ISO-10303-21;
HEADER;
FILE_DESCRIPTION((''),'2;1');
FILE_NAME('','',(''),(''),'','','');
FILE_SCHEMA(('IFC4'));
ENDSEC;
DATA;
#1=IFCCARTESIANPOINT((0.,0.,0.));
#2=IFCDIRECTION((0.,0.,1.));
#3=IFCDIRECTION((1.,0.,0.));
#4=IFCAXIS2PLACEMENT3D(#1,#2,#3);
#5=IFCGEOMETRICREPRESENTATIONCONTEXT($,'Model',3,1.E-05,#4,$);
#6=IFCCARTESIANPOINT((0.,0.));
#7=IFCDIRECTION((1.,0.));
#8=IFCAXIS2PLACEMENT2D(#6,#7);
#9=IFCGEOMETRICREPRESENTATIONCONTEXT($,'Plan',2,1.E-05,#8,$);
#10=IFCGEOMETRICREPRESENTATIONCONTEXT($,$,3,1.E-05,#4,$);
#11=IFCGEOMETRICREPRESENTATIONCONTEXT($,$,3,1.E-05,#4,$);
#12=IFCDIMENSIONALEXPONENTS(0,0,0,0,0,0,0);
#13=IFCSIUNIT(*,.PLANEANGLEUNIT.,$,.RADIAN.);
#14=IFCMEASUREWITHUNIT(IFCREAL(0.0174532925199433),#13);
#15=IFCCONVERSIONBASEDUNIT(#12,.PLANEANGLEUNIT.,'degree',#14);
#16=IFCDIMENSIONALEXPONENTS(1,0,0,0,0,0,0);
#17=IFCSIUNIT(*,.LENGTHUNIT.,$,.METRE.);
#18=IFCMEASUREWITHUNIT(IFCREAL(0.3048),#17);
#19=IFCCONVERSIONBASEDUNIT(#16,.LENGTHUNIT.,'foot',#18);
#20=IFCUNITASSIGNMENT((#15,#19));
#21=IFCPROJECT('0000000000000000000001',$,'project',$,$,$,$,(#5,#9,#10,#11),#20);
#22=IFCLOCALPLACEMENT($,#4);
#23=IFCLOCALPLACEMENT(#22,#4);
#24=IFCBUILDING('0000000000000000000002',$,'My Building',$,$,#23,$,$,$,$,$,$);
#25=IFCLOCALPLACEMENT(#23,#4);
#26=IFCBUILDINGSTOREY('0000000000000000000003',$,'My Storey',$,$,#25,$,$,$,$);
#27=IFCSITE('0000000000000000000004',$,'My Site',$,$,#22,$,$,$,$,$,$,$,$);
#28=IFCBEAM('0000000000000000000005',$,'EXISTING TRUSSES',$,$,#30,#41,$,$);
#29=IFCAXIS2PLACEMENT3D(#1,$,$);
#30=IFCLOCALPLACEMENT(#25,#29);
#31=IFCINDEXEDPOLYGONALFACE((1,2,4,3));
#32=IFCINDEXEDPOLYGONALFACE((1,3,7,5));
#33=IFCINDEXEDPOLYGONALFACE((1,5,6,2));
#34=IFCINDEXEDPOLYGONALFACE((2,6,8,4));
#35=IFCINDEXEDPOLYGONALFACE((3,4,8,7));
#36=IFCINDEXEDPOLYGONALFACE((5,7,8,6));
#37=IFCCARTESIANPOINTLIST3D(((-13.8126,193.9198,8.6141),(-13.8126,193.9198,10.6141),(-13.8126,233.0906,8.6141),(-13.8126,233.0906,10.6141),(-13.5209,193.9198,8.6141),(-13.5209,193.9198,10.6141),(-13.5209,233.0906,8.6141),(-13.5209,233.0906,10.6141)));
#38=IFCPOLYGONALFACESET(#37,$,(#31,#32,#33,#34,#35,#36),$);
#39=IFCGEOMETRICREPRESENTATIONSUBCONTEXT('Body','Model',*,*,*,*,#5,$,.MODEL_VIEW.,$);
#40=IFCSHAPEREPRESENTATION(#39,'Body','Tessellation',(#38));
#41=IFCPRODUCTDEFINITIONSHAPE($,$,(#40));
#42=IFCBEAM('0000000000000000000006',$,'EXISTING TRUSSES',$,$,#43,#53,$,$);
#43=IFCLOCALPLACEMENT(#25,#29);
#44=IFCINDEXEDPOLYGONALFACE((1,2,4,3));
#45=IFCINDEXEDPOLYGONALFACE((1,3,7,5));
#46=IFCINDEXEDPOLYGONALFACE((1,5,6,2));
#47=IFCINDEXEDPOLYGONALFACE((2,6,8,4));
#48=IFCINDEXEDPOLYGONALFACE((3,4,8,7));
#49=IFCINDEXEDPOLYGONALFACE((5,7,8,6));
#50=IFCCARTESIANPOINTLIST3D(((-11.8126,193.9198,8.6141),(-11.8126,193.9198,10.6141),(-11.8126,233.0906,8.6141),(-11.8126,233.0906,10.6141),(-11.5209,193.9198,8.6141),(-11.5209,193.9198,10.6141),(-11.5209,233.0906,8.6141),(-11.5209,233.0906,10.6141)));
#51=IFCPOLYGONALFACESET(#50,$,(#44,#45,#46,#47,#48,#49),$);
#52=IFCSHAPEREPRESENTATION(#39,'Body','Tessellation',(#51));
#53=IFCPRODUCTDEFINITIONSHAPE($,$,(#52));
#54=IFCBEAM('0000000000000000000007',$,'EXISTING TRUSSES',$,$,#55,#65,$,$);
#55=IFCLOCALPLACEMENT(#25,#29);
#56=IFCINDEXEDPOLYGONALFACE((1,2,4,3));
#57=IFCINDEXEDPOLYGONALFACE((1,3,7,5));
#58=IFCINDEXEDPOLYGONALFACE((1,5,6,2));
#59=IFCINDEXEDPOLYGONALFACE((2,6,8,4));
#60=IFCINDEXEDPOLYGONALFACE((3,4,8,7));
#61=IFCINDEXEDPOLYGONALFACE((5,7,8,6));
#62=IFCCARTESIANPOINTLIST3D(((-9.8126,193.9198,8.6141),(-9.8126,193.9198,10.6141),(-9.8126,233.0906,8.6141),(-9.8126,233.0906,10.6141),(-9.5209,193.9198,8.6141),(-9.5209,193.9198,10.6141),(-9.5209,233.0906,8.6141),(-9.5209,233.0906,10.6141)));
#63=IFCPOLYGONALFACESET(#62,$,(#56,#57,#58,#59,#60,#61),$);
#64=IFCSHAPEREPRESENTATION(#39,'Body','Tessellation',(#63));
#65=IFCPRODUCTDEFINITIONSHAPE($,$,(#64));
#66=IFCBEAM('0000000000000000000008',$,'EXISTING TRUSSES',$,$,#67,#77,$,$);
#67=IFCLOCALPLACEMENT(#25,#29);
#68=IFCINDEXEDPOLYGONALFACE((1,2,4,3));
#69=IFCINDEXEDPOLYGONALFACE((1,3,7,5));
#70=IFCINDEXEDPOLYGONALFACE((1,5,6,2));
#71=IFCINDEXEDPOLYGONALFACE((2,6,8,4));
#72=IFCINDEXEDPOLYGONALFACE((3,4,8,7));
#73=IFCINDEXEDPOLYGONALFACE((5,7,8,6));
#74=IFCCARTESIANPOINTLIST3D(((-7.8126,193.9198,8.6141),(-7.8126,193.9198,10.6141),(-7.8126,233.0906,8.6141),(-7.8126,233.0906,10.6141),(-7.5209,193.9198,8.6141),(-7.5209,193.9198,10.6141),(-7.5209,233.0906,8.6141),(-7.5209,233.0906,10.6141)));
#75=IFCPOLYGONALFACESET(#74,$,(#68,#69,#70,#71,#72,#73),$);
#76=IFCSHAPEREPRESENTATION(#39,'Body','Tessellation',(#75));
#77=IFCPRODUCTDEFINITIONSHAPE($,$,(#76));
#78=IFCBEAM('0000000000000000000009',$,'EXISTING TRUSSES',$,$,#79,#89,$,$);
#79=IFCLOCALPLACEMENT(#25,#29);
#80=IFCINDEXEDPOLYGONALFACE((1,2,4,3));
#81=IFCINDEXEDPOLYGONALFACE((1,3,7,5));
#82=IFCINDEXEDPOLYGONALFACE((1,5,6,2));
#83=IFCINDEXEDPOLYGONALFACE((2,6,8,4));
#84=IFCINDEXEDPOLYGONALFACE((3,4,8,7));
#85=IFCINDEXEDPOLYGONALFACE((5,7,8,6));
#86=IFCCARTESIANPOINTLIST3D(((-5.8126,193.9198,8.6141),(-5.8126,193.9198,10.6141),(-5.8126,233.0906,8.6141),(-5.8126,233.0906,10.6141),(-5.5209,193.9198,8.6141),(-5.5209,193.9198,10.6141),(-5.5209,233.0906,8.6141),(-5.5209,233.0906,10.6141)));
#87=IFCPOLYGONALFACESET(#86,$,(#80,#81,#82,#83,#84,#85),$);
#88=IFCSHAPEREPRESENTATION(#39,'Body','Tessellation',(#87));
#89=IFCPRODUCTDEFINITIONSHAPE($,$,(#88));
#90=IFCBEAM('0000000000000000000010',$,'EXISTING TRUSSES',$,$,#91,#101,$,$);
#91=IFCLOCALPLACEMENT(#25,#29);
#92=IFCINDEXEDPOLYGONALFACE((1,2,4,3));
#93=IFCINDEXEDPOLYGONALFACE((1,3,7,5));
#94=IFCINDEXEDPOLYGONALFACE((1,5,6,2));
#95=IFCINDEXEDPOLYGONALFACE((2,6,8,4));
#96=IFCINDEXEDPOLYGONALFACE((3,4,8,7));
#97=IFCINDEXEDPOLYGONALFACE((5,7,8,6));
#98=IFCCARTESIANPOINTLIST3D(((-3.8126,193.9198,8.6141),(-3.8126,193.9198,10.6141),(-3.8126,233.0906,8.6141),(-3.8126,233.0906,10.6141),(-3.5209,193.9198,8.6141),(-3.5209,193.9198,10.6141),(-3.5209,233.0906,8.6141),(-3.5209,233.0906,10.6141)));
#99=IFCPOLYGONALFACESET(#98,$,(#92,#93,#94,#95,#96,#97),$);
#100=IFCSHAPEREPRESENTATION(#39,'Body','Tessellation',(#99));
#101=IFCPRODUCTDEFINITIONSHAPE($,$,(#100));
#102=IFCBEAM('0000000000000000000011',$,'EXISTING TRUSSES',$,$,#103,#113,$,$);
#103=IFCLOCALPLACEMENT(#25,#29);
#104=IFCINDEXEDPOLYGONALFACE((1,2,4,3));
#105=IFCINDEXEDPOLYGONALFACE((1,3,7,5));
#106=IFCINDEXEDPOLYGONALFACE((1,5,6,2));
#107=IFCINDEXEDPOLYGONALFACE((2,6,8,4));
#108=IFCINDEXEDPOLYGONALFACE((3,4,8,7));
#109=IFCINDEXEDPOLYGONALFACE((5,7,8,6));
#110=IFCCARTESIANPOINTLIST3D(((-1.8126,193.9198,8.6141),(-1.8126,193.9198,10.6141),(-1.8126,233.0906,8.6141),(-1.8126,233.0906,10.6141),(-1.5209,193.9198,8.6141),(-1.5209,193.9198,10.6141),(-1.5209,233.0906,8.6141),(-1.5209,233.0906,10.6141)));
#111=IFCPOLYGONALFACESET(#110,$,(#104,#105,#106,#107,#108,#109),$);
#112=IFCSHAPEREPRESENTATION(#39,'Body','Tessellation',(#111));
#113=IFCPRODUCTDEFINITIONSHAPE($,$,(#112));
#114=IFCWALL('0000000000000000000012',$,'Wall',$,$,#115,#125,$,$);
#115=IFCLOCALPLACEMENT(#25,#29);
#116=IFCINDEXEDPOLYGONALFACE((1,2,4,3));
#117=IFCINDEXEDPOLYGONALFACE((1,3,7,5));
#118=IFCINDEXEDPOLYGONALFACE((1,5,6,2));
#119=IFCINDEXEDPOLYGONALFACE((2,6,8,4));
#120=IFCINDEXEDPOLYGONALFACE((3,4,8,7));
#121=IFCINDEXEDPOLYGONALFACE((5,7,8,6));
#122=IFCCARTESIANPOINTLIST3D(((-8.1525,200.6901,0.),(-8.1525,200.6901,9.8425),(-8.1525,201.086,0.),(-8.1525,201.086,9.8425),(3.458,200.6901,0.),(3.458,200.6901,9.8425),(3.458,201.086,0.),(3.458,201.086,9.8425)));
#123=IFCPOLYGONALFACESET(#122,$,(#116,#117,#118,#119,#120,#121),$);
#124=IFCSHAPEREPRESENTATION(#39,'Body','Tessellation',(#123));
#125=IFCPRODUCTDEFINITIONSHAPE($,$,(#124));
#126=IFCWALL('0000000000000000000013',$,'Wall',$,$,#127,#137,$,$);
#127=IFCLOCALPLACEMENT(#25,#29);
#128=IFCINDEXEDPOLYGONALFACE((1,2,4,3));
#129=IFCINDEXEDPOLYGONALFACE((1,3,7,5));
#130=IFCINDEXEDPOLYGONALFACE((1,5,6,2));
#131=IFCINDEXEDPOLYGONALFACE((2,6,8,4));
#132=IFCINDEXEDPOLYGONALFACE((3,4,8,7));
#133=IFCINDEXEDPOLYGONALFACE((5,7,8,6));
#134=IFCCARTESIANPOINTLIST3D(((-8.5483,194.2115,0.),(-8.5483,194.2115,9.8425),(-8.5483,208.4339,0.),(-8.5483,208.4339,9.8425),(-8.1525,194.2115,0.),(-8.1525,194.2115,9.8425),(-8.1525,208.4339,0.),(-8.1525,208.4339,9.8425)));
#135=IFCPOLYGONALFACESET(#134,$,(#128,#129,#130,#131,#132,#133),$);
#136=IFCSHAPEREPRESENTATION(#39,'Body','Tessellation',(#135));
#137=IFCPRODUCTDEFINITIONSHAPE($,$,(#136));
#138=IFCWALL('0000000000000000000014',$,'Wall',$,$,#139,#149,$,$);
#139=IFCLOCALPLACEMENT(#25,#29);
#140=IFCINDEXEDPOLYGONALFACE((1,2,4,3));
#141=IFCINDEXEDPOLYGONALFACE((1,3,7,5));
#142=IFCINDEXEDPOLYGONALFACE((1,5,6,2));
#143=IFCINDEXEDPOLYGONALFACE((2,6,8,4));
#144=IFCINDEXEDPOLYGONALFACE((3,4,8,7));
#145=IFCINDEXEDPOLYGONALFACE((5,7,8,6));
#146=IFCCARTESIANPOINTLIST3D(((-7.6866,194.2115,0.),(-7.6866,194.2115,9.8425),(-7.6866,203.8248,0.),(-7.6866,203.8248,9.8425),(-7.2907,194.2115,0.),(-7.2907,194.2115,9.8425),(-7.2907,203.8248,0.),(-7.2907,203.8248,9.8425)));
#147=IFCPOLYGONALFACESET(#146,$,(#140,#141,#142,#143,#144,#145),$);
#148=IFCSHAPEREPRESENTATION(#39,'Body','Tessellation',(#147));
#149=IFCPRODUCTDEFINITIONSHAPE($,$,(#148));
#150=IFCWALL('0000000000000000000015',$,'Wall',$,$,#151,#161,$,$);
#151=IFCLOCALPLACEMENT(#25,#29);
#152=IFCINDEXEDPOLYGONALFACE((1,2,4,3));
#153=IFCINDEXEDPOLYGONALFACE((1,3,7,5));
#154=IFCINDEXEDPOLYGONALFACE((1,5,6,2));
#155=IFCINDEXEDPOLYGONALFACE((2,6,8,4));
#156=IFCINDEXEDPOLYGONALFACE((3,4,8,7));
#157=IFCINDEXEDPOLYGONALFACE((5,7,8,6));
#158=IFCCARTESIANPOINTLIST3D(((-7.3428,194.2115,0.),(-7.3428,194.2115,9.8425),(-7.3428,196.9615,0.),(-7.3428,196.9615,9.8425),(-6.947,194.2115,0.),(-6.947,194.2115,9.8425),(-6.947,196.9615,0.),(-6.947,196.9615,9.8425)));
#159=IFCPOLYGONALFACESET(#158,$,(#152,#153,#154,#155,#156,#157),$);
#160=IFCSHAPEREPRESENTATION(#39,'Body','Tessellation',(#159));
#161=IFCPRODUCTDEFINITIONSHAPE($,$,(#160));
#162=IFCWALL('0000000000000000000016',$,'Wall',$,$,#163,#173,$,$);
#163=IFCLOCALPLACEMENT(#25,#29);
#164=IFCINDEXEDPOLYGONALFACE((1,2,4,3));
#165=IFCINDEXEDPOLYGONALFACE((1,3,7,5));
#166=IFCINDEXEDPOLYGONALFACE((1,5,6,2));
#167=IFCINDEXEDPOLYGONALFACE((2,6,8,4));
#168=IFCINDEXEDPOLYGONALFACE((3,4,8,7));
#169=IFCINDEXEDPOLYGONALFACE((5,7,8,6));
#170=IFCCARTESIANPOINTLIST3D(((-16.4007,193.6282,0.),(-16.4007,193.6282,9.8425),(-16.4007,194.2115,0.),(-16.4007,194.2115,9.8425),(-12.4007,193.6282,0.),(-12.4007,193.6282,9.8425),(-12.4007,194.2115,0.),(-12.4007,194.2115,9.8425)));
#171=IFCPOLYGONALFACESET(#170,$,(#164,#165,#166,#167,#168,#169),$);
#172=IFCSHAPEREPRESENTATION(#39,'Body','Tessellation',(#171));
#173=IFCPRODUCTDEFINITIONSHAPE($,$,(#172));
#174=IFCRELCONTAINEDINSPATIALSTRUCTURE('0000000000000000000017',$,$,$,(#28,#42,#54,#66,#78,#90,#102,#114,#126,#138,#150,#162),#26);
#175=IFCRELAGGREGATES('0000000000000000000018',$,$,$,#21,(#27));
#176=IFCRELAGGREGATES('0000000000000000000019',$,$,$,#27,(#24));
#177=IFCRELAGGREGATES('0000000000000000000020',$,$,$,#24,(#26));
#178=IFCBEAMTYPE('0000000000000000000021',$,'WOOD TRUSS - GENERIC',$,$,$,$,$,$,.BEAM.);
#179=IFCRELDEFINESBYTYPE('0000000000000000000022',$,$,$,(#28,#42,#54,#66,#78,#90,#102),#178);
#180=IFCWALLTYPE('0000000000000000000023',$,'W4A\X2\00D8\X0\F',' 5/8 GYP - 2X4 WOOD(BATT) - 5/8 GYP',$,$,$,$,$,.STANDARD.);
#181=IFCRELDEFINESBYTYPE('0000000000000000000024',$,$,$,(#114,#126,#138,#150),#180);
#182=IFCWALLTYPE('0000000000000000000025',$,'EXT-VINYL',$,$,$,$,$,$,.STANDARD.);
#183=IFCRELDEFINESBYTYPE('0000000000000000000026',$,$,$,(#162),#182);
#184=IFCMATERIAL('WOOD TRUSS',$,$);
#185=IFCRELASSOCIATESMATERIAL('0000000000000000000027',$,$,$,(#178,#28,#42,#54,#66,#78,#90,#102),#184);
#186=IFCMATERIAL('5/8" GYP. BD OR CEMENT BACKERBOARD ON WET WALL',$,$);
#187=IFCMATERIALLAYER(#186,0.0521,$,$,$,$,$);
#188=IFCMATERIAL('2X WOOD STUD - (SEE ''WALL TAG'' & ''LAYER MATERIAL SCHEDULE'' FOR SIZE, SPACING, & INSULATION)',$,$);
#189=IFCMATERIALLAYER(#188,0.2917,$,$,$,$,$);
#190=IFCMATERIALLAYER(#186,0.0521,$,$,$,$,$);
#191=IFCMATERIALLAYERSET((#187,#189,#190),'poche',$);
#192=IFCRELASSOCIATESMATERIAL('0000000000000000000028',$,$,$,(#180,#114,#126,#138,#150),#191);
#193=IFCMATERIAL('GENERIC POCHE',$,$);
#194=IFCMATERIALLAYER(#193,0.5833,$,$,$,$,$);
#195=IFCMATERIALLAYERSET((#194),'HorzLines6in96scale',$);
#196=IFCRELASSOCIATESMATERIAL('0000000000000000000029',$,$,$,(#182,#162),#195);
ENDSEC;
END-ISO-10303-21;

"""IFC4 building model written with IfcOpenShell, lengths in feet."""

from ifc_helpers import new_model, entity, si_unit, converted_unit, frame, origin_with_axes, origin_2d_with_axis, place, context, subcontext, project, spatial, indexed_curve, rectangle, outline, extrude, material, layer, layer_set, layer_usage, material_profile, profile_set, profile_usage, type_object, element, save


model = new_model("IFC4")

# Units and contexts
model_context = context("Model", 3, precision=1e-05, world=origin_with_axes())
plan_context = context("Plan", 2, precision=1e-05, world=origin_2d_with_axis())
context_of_model_1 = context(None, 3, precision=1e-05, world=origin_with_axes())
context_of_model_2 = context(None, 3, precision=1e-05, world=origin_with_axes())
body_context_1 = subcontext(model_context, "Body", "Model", "MODEL_VIEW")
ifc_project = project(units=[converted_unit("PLANEANGLEUNIT", "degree", entity("IfcReal", 0.0174532925199433), si_unit("PLANEANGLEUNIT", "RADIAN"), dimensions=[0, 0, 0, 0, 0, 0, 0]), converted_unit("LENGTHUNIT", "foot", entity("IfcReal", 0.3048), si_unit("LENGTHUNIT", "METRE"), dimensions=[1, 0, 0, 0, 0, 0, 0])], contexts=[model_context, plan_context, context_of_model_1, context_of_model_2])

# Site, building, storey
site_placement = place(None, origin_with_axes())
site = spatial("IfcSite", under=ifc_project, at=site_placement, Name="My Site")
building_placement = place(site_placement, origin_with_axes())
building = spatial("IfcBuilding", under=site, at=building_placement, Name="My Building")
storey_placement = place(building_placement, origin_with_axes())
storey = spatial("IfcBuildingStorey", under=building, at=storey_placement, Name="My Storey")

# Beams
ifc_material_1 = material(Name="WOOD TRUSS")
ifc_material_profile = material_profile(ifc_material_1, rectangle(XDim=0.2917, YDim=2.0))
ifc_profile_set = profile_set([ifc_material_profile])
ifc_profile_usage_1 = profile_usage(ifc_profile_set, cardinal=5)
beam_type = type_object("IfcBeamType", Name="WOOD TRUSS - GENERIC", PredefinedType="BEAM", material=ifc_profile_set)
beam_1_placement = place(storey_placement, frame((-13.6667, 193.9198, 9.6141), z_axis=(0.0, 1.0, 0.0), x_axis=(-1.0, 0.0, 0.0)))
element("IfcBeam", 1, at=beam_1_placement, inside=storey, type_object=beam_type, material=ifc_profile_usage_1, Name="EXISTING TRUSSES", context=body_context_1, shape_type="SweptSolid", body=[
    extrude(rectangle(XDim=0.2917, YDim=2.0), origin_with_axes(), (0.0, 0.0, 1.0), 39.1707),
])
ifc_profile_usage_2 = profile_usage(ifc_profile_set, cardinal=5)
beam_2_placement = place(storey_placement, frame((-11.6667, 193.9198, 9.6141), z_axis=(0.0, 1.0, 0.0), x_axis=(-1.0, 0.0, 0.0)))
element("IfcBeam", 2, at=beam_2_placement, inside=storey, type_object=beam_type, material=ifc_profile_usage_2, Name="EXISTING TRUSSES", context=body_context_1, shape_type="SweptSolid", body=[
    extrude(rectangle(XDim=0.2917, YDim=2.0), origin_with_axes(), (0.0, 0.0, 1.0), 39.1707),
])
ifc_profile_usage_3 = profile_usage(ifc_profile_set, cardinal=5)
beam_3_placement = place(storey_placement, frame((-9.6667, 193.9198, 9.6141), z_axis=(0.0, 1.0, 0.0), x_axis=(-1.0, 0.0, 0.0)))
element("IfcBeam", 3, at=beam_3_placement, inside=storey, type_object=beam_type, material=ifc_profile_usage_3, Name="EXISTING TRUSSES", context=body_context_1, shape_type="SweptSolid", body=[
    extrude(rectangle(XDim=0.2917, YDim=2.0), origin_with_axes(), (0.0, 0.0, 1.0), 39.1707),
])
ifc_profile_usage_4 = profile_usage(ifc_profile_set, cardinal=5)
beam_4_placement = place(storey_placement, frame((-7.6667, 193.9198, 9.6141), z_axis=(0.0, 1.0, 0.0), x_axis=(-1.0, 0.0, 0.0)))
element("IfcBeam", 4, at=beam_4_placement, inside=storey, type_object=beam_type, material=ifc_profile_usage_4, Name="EXISTING TRUSSES", context=body_context_1, shape_type="SweptSolid", body=[
    extrude(rectangle(XDim=0.2917, YDim=2.0), origin_with_axes(), (0.0, 0.0, 1.0), 39.1707),
])
ifc_profile_usage_5 = profile_usage(ifc_profile_set, cardinal=5)
beam_5_placement = place(storey_placement, frame((-5.6667, 193.9198, 9.6141), z_axis=(0.0, 1.0, 0.0), x_axis=(-1.0, 0.0, 0.0)))
element("IfcBeam", 5, at=beam_5_placement, inside=storey, type_object=beam_type, material=ifc_profile_usage_5, Name="EXISTING TRUSSES", context=body_context_1, shape_type="SweptSolid", body=[
    extrude(rectangle(XDim=0.2917, YDim=2.0), origin_with_axes(), (0.0, 0.0, 1.0), 39.1707),
])
ifc_profile_usage_6 = profile_usage(ifc_profile_set, cardinal=5)
beam_6_placement = place(storey_placement, frame((-3.6667, 193.9198, 9.6141), z_axis=(0.0, 1.0, 0.0), x_axis=(-1.0, 0.0, 0.0)))
element("IfcBeam", 6, at=beam_6_placement, inside=storey, type_object=beam_type, material=ifc_profile_usage_6, Name="EXISTING TRUSSES", context=body_context_1, shape_type="SweptSolid", body=[
    extrude(rectangle(XDim=0.2917, YDim=2.0), origin_with_axes(), (0.0, 0.0, 1.0), 39.1707),
])
ifc_profile_usage_7 = profile_usage(ifc_profile_set, cardinal=5)
beam_7_placement = place(storey_placement, frame((-1.6667, 193.9198, 9.6141), z_axis=(0.0, 1.0, 0.0), x_axis=(-1.0, 0.0, 0.0)))
element("IfcBeam", 7, at=beam_7_placement, inside=storey, type_object=beam_type, material=ifc_profile_usage_7, Name="EXISTING TRUSSES", context=body_context_1, shape_type="SweptSolid", body=[
    extrude(rectangle(XDim=0.2917, YDim=2.0), origin_with_axes(), (0.0, 0.0, 1.0), 39.1707),
])

# Walls
ifc_material_2 = material(Name="5/8\" GYP. BD OR CEMENT BACKERBOARD ON WET WALL")
ifc_layer_1 = layer(ifc_material_2, 0.0521)
ifc_material_3 = material(Name="2X WOOD STUD - (SEE 'WALL TAG' & 'LAYER MATERIAL SCHEDULE' FOR SIZE, SPACING, & INSULATION)")
ifc_layer_2 = layer(ifc_material_3, 0.2917)
ifc_layer_3 = layer(ifc_material_2, 0.0521)
ifc_layer_set_1 = layer_set([ifc_layer_1, ifc_layer_2, ifc_layer_3], Name="poche")
ifc_layer_usage_1 = layer_usage(ifc_layer_set_1, "AXIS2", "POSITIVE", 0.0)
wall_type_1 = type_object("IfcWallType", Name="W4AØF", Description=" 5/8 GYP - 2X4 WOOD(BATT) - 5/8 GYP", PredefinedType="STANDARD", material=ifc_layer_set_1)
wall_1_placement = place(storey_placement, frame((-8.1525, 200.6901, 0.0), z_axis=(0.0, 0.0, 1.0), x_axis=(1.0, 0.0, 0.0)))
element("IfcWall", 8, at=wall_1_placement, inside=storey, type_object=wall_type_1, material=ifc_layer_usage_1, Name="Wall", context=body_context_1, shape_type="SweptSolid", body=[
    extrude(outline(indexed_curve([(0.0, 0.0), (0.0, 0.3958), (11.6105, 0.3958), (11.6105, 0.0), (0.0, 0.0)], self_intersect=False)), origin_with_axes(), (0.0, 0.0, 1.0), 9.8425),
])
ifc_layer_usage_2 = layer_usage(ifc_layer_set_1, "AXIS2", "POSITIVE", 0.0)
wall_2_placement = place(storey_placement, frame((-8.1525, 194.2115, 0.0), z_axis=(0.0, 0.0, 1.0), x_axis=(0.000001, 1.0, 0.0)))
element("IfcWall", 9, at=wall_2_placement, inside=storey, type_object=wall_type_1, material=ifc_layer_usage_2, Name="Wall", context=body_context_1, shape_type="SweptSolid", body=[
    extrude(outline(indexed_curve([(0.0, 0.0), (0.0, 0.3958), (14.2224, 0.3958), (14.2224, 0.0), (0.0, 0.0)], self_intersect=False)), origin_with_axes(), (0.0, 0.0, 1.0), 9.8425),
])

# Wall
ifc_layer_usage_3 = layer_usage(ifc_layer_set_1, "AXIS2", "POSITIVE", 0.0)
wall_3_placement = place(storey_placement, frame((-7.2907, 194.2115, 0.0), z_axis=(0.0, 0.0, 1.0), x_axis=(0.0, 1.0, 0.0)))
element("IfcWall", 10, at=wall_3_placement, inside=storey, type_object=wall_type_1, material=ifc_layer_usage_3, Name="Wall", context=body_context_1, shape_type="SweptSolid", body=[
    extrude(outline(indexed_curve([(0.0, 0.0), (0.0, 0.3958), (9.6133, 0.3958), (9.6133, 0.0), (0.0, 0.0)], self_intersect=False)), origin_with_axes(), (0.0, 0.0, 1.0), 9.8425),
])

# Walls
ifc_layer_usage_4 = layer_usage(ifc_layer_set_1, "AXIS2", "POSITIVE", 0.0)
wall_4_placement = place(storey_placement, frame((-6.947, 194.2115, 0.0), z_axis=(0.0, 0.0, 1.0), x_axis=(0.0, 1.0, 0.0)))
element("IfcWall", 11, at=wall_4_placement, inside=storey, type_object=wall_type_1, material=ifc_layer_usage_4, Name="Wall", context=body_context_1, shape_type="SweptSolid", body=[
    extrude(outline(indexed_curve([(0.0, 0.0), (0.0, 0.3958), (2.75, 0.3958), (2.75, 0.0), (0.0, 0.0)], self_intersect=False)), origin_with_axes(), (0.0, 0.0, 1.0), 9.8425),
])
ifc_material_4 = material(Name="GENERIC POCHE")
ifc_layer_4 = layer(ifc_material_4, 0.5833)
ifc_layer_set_2 = layer_set([ifc_layer_4], Name="HorzLines6in96scale")
ifc_layer_usage_5 = layer_usage(ifc_layer_set_2, "AXIS2", "POSITIVE", 0.0)
wall_type_2 = type_object("IfcWallType", Name="EXT-VINYL", PredefinedType="STANDARD", material=ifc_layer_set_2)
wall_5_placement = place(storey_placement, frame((-12.4007, 194.2115, 0.0), z_axis=(0.0, 0.0, 1.0), x_axis=(-1.0, 0.0, 0.0)))
element("IfcWall", 12, at=wall_5_placement, inside=storey, type_object=wall_type_2, material=ifc_layer_usage_5, Name="Wall", context=body_context_1, shape_type="SweptSolid", body=[
    extrude(outline(indexed_curve([(0.0, 0.0), (0.0, 0.5833), (4.0, 0.5833), (4.0, 0.0), (0.0, 0.0)], self_intersect=False)), origin_with_axes(), (0.0, 0.0, 1.0), 9.8425),
])

save(model, "model.ifc")
